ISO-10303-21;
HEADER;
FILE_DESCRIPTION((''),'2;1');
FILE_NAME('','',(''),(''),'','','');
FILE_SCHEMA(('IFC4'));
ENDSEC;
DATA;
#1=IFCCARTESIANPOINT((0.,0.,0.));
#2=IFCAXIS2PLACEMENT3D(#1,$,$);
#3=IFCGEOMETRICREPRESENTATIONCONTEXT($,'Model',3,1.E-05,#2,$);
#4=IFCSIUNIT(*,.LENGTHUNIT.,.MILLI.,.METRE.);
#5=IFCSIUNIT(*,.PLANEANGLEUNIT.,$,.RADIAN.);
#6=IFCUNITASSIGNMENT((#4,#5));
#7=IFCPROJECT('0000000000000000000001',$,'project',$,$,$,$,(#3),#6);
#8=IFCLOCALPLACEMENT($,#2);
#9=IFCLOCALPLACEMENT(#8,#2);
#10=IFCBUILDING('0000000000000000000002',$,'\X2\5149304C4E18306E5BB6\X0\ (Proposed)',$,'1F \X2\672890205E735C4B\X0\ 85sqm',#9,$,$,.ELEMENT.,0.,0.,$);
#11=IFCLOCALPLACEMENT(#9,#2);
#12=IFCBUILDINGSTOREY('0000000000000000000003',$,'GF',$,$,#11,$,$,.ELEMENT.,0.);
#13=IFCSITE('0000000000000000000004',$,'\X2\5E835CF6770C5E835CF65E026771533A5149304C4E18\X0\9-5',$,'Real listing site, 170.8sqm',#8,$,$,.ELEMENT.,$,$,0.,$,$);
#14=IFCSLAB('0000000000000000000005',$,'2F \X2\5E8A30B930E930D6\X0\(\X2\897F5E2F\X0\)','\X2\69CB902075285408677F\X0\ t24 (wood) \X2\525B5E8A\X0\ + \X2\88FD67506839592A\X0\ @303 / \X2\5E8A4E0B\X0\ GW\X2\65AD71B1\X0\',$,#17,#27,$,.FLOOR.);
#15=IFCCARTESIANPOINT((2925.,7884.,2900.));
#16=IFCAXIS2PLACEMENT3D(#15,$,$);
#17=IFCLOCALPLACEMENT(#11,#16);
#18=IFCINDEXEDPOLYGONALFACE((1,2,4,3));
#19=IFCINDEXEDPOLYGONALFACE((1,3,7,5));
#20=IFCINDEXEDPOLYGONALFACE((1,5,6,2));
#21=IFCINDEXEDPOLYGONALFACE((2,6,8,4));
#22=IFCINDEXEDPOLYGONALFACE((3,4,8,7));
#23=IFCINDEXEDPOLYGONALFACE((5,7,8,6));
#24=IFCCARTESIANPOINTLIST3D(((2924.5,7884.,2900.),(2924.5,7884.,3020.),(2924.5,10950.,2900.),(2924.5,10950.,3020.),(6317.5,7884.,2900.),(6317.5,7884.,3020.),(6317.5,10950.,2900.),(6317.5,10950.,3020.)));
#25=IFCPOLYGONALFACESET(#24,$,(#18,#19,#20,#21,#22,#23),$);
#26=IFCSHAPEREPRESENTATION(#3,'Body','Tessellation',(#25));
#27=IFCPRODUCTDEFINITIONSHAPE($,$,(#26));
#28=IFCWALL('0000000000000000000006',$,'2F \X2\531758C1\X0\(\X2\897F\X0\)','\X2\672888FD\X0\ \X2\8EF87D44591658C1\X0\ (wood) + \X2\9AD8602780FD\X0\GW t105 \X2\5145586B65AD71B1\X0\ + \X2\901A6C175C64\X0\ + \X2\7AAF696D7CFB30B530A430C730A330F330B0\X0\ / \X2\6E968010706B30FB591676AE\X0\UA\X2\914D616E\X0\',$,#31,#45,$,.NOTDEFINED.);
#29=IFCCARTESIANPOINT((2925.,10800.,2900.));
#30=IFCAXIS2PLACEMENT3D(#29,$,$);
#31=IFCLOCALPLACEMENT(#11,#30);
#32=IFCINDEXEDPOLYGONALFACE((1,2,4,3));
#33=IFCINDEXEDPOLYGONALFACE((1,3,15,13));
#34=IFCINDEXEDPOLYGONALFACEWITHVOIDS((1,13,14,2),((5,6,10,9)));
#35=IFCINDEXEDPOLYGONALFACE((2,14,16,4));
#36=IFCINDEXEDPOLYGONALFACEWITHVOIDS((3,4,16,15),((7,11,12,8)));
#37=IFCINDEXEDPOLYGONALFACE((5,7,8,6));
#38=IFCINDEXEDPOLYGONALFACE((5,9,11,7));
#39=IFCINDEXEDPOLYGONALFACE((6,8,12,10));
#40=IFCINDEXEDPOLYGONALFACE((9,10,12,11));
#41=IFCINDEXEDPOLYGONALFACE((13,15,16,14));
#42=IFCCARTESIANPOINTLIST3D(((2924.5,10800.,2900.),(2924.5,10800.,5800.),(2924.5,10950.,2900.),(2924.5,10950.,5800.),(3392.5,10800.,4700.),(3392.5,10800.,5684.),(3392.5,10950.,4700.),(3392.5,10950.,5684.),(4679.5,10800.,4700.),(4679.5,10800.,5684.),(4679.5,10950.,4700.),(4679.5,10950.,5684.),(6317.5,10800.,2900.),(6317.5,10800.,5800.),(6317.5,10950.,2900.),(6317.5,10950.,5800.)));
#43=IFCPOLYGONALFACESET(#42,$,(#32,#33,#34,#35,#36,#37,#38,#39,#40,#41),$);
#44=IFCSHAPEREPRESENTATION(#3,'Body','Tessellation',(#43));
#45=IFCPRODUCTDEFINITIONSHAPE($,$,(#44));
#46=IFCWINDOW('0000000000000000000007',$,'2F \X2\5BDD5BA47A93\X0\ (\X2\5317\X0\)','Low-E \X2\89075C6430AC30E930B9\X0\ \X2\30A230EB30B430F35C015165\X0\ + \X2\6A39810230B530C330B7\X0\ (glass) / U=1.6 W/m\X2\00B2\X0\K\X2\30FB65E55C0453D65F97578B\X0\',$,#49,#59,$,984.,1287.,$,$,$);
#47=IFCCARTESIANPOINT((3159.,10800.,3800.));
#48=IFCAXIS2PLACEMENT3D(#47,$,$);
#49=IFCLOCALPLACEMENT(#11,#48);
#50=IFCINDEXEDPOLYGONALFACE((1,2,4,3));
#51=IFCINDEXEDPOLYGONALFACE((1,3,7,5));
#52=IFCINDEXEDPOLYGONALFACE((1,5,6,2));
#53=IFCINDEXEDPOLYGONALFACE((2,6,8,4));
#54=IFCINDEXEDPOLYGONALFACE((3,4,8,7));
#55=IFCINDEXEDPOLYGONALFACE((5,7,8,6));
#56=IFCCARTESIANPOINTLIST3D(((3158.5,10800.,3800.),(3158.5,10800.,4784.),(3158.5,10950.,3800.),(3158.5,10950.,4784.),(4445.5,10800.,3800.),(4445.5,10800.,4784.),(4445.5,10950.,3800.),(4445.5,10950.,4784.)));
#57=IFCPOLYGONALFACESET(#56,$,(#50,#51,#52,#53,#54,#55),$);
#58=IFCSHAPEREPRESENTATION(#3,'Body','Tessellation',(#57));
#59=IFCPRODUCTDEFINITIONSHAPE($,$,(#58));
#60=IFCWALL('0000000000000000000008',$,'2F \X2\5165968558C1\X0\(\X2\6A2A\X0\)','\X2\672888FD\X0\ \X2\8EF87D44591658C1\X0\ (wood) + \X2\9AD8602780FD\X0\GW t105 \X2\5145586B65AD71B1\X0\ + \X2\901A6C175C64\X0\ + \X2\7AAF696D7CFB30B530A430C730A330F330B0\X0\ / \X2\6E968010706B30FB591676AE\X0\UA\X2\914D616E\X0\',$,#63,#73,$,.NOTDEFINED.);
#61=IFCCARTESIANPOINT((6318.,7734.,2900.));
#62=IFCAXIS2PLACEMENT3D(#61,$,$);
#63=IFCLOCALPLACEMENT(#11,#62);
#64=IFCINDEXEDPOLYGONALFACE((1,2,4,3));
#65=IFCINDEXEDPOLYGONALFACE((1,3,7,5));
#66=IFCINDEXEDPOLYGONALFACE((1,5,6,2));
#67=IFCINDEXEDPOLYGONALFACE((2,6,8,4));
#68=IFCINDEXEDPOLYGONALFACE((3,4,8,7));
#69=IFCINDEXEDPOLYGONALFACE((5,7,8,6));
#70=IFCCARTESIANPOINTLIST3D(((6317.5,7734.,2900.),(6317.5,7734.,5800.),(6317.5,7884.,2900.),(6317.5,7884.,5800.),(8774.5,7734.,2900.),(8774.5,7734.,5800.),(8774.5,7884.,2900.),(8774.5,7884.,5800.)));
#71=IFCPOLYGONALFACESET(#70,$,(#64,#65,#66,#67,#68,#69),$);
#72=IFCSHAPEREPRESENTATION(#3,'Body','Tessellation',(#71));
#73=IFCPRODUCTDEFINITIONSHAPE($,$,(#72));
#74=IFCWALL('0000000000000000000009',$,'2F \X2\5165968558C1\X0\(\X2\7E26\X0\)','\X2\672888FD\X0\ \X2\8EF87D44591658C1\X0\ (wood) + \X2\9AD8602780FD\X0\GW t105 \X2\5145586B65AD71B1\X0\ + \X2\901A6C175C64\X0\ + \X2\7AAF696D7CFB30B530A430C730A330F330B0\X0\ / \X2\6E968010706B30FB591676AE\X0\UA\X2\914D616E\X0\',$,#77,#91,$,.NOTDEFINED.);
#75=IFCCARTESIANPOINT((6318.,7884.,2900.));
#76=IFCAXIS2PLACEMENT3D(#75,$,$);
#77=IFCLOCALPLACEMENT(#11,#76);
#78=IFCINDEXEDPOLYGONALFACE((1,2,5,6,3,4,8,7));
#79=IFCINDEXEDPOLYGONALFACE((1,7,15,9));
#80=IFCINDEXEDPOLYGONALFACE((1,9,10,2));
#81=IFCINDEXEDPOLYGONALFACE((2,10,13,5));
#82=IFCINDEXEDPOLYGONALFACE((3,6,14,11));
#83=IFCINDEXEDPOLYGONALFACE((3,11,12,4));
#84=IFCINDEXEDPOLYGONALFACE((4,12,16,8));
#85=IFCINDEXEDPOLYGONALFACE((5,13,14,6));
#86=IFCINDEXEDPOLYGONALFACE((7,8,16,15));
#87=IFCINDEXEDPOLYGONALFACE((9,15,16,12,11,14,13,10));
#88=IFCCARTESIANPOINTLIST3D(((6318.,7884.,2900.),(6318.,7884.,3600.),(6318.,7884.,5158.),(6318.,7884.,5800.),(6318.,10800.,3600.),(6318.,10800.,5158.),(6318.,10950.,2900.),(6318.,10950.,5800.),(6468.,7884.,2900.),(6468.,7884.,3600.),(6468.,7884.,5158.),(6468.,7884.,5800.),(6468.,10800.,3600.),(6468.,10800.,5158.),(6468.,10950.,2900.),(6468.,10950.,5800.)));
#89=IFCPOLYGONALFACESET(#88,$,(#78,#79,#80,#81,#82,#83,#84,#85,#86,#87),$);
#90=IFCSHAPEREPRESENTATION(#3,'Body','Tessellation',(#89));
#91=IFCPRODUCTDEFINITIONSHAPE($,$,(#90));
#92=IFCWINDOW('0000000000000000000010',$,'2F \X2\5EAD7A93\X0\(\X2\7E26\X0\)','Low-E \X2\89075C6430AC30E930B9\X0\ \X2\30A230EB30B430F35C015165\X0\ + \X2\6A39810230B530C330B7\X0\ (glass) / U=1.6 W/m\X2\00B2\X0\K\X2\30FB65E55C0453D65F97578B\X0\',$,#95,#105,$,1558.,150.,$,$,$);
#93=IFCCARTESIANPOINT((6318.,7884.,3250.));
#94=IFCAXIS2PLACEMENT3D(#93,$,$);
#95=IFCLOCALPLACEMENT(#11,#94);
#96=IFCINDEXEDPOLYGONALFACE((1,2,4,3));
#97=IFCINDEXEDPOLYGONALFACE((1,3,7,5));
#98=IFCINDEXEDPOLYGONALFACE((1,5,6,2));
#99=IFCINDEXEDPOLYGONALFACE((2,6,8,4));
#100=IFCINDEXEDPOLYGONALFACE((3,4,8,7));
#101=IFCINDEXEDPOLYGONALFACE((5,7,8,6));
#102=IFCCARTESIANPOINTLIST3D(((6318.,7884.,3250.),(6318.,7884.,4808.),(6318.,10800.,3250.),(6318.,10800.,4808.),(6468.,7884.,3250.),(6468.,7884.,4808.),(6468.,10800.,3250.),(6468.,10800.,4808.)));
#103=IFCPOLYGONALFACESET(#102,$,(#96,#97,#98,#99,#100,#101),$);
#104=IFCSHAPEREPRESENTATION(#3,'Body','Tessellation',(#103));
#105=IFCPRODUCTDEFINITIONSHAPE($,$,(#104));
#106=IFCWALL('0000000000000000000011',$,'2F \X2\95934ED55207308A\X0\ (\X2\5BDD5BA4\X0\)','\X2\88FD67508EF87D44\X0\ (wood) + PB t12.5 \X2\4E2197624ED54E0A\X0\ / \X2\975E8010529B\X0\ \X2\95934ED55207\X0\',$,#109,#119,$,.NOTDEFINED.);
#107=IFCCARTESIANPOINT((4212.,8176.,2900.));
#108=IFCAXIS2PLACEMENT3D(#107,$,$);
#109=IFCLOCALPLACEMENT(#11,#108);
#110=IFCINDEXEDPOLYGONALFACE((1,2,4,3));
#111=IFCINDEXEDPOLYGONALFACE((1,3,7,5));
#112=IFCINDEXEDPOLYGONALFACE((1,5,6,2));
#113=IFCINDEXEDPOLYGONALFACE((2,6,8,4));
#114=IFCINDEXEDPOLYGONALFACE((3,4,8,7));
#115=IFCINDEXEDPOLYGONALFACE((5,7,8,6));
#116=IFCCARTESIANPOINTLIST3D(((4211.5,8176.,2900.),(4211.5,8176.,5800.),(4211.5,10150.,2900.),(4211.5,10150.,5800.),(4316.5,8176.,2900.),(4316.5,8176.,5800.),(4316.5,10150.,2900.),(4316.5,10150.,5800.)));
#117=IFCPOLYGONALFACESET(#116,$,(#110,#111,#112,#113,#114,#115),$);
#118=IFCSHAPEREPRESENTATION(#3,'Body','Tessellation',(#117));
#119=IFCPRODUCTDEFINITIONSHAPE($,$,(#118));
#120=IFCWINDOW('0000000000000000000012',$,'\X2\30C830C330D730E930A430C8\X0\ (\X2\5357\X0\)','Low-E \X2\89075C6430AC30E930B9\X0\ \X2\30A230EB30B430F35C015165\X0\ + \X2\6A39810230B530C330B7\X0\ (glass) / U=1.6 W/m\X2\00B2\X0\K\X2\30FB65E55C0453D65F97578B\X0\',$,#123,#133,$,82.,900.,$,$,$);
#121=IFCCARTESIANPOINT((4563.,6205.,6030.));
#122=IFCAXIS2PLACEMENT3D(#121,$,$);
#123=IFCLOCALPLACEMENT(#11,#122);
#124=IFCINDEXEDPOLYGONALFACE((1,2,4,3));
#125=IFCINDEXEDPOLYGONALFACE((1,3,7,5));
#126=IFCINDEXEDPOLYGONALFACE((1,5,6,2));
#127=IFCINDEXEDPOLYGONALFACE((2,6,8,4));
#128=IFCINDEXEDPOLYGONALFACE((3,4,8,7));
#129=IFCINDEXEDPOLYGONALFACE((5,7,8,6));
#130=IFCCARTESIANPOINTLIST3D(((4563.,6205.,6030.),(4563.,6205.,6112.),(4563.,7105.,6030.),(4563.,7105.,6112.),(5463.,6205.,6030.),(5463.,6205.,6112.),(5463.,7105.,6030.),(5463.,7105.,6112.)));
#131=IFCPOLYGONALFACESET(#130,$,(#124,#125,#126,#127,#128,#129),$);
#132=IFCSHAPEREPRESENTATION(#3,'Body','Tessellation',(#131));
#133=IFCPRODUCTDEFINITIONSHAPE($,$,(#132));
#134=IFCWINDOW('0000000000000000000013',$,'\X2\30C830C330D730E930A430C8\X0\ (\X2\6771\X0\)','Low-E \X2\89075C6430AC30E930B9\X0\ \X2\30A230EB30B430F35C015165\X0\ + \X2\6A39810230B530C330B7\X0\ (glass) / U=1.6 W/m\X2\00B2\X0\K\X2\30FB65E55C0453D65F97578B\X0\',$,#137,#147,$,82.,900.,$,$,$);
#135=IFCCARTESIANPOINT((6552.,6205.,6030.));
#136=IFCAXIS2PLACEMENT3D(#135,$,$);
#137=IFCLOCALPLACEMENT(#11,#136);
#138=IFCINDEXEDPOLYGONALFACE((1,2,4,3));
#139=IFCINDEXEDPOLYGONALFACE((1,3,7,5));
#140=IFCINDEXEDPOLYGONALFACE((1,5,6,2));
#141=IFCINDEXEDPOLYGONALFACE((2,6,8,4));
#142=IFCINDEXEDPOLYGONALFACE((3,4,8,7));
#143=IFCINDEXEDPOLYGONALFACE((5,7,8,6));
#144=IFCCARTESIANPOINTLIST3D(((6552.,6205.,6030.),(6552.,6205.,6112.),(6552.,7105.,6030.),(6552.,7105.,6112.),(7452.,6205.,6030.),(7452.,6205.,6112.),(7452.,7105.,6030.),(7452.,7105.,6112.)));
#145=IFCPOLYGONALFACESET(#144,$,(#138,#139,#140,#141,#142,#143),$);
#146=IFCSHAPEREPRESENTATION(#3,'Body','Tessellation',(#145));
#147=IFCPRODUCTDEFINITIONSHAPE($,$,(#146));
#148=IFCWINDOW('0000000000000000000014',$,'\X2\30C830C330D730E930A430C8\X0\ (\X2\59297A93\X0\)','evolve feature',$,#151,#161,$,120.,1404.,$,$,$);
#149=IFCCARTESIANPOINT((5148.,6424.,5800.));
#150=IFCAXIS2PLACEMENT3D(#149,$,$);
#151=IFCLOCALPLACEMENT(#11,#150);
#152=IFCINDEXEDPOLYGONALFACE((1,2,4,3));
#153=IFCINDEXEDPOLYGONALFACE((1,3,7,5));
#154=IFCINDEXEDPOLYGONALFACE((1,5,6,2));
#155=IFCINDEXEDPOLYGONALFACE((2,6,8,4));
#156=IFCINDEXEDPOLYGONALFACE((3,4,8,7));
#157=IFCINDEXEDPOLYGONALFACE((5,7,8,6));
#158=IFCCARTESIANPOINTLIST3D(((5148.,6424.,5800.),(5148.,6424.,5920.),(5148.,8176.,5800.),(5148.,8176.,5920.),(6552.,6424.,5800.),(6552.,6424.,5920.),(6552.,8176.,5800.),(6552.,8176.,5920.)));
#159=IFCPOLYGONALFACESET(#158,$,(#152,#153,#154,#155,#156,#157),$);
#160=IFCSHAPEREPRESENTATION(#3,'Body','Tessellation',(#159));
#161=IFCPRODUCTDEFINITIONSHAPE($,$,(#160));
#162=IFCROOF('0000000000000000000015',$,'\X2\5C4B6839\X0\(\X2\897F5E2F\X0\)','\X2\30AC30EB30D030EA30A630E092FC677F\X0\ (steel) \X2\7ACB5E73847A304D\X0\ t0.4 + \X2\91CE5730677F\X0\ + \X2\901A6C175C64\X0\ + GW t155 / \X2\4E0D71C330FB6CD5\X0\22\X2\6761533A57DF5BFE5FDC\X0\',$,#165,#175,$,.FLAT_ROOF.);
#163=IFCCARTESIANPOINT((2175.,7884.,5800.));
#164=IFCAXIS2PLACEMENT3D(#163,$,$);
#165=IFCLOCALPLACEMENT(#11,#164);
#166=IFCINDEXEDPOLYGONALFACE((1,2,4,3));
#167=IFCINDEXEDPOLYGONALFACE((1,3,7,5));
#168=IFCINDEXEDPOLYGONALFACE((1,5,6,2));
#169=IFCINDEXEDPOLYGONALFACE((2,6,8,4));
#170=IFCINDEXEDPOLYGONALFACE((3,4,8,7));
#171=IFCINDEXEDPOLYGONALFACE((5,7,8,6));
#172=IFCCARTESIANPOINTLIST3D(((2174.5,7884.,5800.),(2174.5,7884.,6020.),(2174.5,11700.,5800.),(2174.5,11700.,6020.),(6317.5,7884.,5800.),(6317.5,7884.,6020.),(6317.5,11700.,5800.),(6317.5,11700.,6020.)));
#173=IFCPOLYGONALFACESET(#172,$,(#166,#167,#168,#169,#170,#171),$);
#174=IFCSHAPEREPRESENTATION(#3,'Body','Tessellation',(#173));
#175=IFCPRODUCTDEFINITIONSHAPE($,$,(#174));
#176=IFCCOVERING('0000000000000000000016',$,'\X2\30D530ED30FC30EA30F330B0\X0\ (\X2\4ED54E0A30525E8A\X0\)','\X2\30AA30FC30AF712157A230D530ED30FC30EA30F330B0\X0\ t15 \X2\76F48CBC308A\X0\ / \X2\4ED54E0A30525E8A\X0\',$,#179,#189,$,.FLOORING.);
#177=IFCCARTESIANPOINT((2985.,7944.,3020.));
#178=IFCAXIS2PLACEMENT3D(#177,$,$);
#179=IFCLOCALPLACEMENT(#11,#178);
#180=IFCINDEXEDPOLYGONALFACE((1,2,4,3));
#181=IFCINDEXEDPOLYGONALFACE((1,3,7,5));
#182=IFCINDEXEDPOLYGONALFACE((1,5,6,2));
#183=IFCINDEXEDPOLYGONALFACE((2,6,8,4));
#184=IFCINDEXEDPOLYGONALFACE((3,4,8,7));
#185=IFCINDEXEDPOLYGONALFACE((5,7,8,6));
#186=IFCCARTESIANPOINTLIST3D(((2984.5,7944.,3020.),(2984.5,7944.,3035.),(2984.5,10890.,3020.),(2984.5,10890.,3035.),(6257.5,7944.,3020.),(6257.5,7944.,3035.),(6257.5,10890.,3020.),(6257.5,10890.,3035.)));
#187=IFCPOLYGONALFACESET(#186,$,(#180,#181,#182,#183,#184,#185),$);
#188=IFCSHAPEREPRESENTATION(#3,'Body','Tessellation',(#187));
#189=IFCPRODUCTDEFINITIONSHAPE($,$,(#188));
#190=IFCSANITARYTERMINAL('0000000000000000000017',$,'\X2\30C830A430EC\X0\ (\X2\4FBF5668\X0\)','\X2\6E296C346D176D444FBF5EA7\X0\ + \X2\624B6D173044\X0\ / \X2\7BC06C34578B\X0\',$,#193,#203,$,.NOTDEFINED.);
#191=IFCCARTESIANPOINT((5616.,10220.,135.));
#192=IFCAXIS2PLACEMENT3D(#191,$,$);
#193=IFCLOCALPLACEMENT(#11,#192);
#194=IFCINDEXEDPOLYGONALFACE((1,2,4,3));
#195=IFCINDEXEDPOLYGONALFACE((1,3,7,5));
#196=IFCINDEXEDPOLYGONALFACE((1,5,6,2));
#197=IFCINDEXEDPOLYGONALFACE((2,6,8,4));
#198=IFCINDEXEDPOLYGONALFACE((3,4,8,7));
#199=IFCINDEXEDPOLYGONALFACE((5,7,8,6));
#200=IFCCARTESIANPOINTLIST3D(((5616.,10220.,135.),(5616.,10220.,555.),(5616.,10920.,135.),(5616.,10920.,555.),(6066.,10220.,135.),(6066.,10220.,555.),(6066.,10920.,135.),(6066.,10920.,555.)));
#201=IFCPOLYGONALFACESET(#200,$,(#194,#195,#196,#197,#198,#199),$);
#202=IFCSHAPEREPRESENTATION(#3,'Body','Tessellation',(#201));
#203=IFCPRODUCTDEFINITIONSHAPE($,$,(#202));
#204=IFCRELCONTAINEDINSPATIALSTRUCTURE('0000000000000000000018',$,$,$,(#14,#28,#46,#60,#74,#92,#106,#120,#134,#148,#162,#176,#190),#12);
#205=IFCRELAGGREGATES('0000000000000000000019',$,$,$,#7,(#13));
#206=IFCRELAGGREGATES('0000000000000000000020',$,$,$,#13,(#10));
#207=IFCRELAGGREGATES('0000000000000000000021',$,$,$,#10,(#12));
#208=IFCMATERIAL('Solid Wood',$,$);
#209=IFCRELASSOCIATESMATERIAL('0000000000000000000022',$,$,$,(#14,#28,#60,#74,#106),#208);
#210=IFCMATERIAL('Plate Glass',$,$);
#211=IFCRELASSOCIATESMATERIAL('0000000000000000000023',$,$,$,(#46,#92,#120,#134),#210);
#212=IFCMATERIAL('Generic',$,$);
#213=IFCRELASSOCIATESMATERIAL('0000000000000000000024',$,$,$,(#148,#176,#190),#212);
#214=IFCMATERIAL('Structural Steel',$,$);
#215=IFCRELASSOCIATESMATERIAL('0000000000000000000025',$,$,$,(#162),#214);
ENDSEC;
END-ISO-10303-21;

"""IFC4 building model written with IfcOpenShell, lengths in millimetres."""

from ifc_helpers import new_model, si_unit, frame, frame_2d, origin, place, context, project, spatial, rectangle, extrude, material, element, fill, save


model = new_model("IFC4")

# Units and contexts
model_context = context("Model", 3, precision=1e-05, world=origin())
ifc_project = project(units=[si_unit("LENGTHUNIT", "METRE", prefix="MILLI"), si_unit("PLANEANGLEUNIT", "RADIAN")], contexts=[model_context])

# Site, building, storey
site_placement = place(None, origin())
site = spatial("IfcSite", under=ifc_project, at=site_placement, Name="広島県広島市東区光が丘9-5", ObjectType="Real listing site, 170.8sqm", CompositionType="ELEMENT", RefElevation=0.0)
building_placement = place(site_placement, origin())
building = spatial("IfcBuilding", under=site, at=building_placement, Name="光が丘の家 (Proposed)", ObjectType="1F 木造平屋 85sqm", CompositionType="ELEMENT", ElevationOfRefHeight=0.0, ElevationOfTerrain=0.0)
storey_placement = place(building_placement, origin())
storey = spatial("IfcBuildingStorey", under=building, at=storey_placement, Name="GF", CompositionType="ELEMENT", Elevation=0.0)

# Slab
ifc_material_1 = material(Name="Solid Wood")
slab_placement = place(storey_placement, frame((2925.0, 7884.0, 2900.0)))
element("IfcSlab", 1, at=slab_placement, inside=storey, material=ifc_material_1, Name="2F 床スラブ(西帯)", Description="構造用合板 t24 (wood) 剛床 + 製材根太 @303 / 床下 GW断熱", PredefinedType="FLOOR", context=model_context, shape_type="SweptSolid", body=[
    extrude(rectangle(XDim=3393.0, YDim=3066.0, at=frame_2d((1696.0, 1533.0))), frame((2925.0, 7884.0, 2900.0)), (0.0, 0.0, 1.0), 120.0),
])

# Wall, opening, window
wall_1_placement = place(storey_placement, frame((2925.0, 10800.0, 2900.0)))
wall_1 = element("IfcWall", 2, at=wall_1_placement, inside=storey, material=ifc_material_1, Name="2F 北壁(西)", Description="木製 軸組外壁 (wood) + 高性能GW t105 充填断熱 + 通気層 + 窯業系サイディング / 準耐火・外皮UA配慮", PredefinedType="NOTDEFINED", context=model_context, shape_type="SweptSolid", body=[
    extrude(rectangle(XDim=3393.0, YDim=150.0, at=frame_2d((1696.0, 75.0))), frame((2925.0, 10800.0, 2900.0)), (0.0, 0.0, 1.0), 2900.0),
])
opening_1_placement = place(storey_placement, frame((3159.0, 10800.0, 3800.0)))
opening_1 = element("IfcOpeningElement", 3, at=opening_1_placement, cuts=wall_1, PredefinedType="NOTDEFINED", context=model_context, shape_type="SweptSolid", body=[
    extrude(rectangle(XDim=1287.0, YDim=150.0, at=frame_2d((643.0, 75.0))), frame((3159.0, 10800.0, 3800.0)), (0.0, 0.0, 1.0), 984.0),
])
ifc_material_2 = material(Name="Plate Glass")
window_1_placement = place(storey_placement, frame((3159.0, 10800.0, 3800.0)))
window_1 = element("IfcWindow", 4, at=window_1_placement, inside=storey, material=ifc_material_2, Name="2F 寝室窓 (北)", Description="Low-E 複層ガラス アルゴン封入 + 樹脂サッシ (glass) / U=1.6 W/m²K・日射取得型", OverallHeight=984.0, OverallWidth=1287.0, context=model_context, shape_type="SweptSolid", body=[
    extrude(rectangle(XDim=1287.0, YDim=150.0, at=frame_2d((643.0, 75.0))), frame((3159.0, 10800.0, 3800.0)), (0.0, 0.0, 1.0), 984.0),
])
fill(opening_1, window_1)

# Wall
wall_2_placement = place(storey_placement, frame((6318.0, 7734.0, 2900.0)))
element("IfcWall", 5, at=wall_2_placement, inside=storey, material=ifc_material_1, Name="2F 入隅壁(横)", Description="木製 軸組外壁 (wood) + 高性能GW t105 充填断熱 + 通気層 + 窯業系サイディング / 準耐火・外皮UA配慮", PredefinedType="NOTDEFINED", context=model_context, shape_type="SweptSolid", body=[
    extrude(rectangle(XDim=2457.0, YDim=150.0, at=frame_2d((1228.0, 75.0))), frame((6318.0, 7734.0, 2900.0)), (0.0, 0.0, 1.0), 2900.0),
])

# Wall, opening, window
wall_3_placement = place(storey_placement, frame((6318.0, 7884.0, 2900.0)))
wall_3 = element("IfcWall", 6, at=wall_3_placement, inside=storey, material=ifc_material_1, Name="2F 入隅壁(縦)", Description="木製 軸組外壁 (wood) + 高性能GW t105 充填断熱 + 通気層 + 窯業系サイディング / 準耐火・外皮UA配慮", PredefinedType="NOTDEFINED", context=model_context, shape_type="SweptSolid", body=[
    extrude(rectangle(XDim=150.0, YDim=3066.0, at=frame_2d((75.0, 1533.0))), frame((6318.0, 7884.0, 2900.0)), (0.0, 0.0, 1.0), 2900.0),
])
opening_2_placement = place(storey_placement, frame((6318.0, 7884.0, 3250.0)))
opening_2 = element("IfcOpeningElement", 7, at=opening_2_placement, cuts=wall_3, PredefinedType="NOTDEFINED", context=model_context, shape_type="SweptSolid", body=[
    extrude(rectangle(XDim=150.0, YDim=2916.0, at=frame_2d((75.0, 1458.0))), frame((6318.0, 7884.0, 3250.0)), (0.0, 0.0, 1.0), 1558.0),
])
window_2_placement = place(storey_placement, frame((6318.0, 7884.0, 3250.0)))
window_2 = element("IfcWindow", 8, at=window_2_placement, inside=storey, material=ifc_material_2, Name="2F 庭窓(縦)", Description="Low-E 複層ガラス アルゴン封入 + 樹脂サッシ (glass) / U=1.6 W/m²K・日射取得型", OverallHeight=1558.0, OverallWidth=150.0, context=model_context, shape_type="SweptSolid", body=[
    extrude(rectangle(XDim=150.0, YDim=2916.0, at=frame_2d((75.0, 1458.0))), frame((6318.0, 7884.0, 3250.0)), (0.0, 0.0, 1.0), 1558.0),
])
fill(opening_2, window_2)

# Wall
wall_4_placement = place(storey_placement, frame((4212.0, 8176.0, 2900.0)))
element("IfcWall", 9, at=wall_4_placement, inside=storey, material=ifc_material_1, Name="2F 間仕切り (寝室)", Description="製材軸組 (wood) + PB t12.5 両面仕上 / 非耐力 間仕切", PredefinedType="NOTDEFINED", context=model_context, shape_type="SweptSolid", body=[
    extrude(rectangle(XDim=105.0, YDim=1974.0, at=frame_2d((52.0, 987.0))), frame((4212.0, 8176.0, 2900.0)), (0.0, 0.0, 1.0), 2900.0),
])

# Windows
window_3_placement = place(storey_placement, frame((4563.0, 6205.0, 6030.0)))
element("IfcWindow", 10, at=window_3_placement, inside=storey, material=ifc_material_2, Name="トップライト (南)", Description="Low-E 複層ガラス アルゴン封入 + 樹脂サッシ (glass) / U=1.6 W/m²K・日射取得型", OverallHeight=82.0, OverallWidth=900.0, context=model_context, shape_type="SweptSolid", body=[
    extrude(rectangle(XDim=900.0, YDim=900.0, at=frame_2d((450.0, 450.0))), frame((4563.0, 6205.0, 6030.0)), (0.0, 0.0, 1.0), 82.0),
])
window_4_placement = place(storey_placement, frame((6552.0, 6205.0, 6030.0)))
element("IfcWindow", 11, at=window_4_placement, inside=storey, material=ifc_material_2, Name="トップライト (東)", Description="Low-E 複層ガラス アルゴン封入 + 樹脂サッシ (glass) / U=1.6 W/m²K・日射取得型", OverallHeight=82.0, OverallWidth=900.0, context=model_context, shape_type="SweptSolid", body=[
    extrude(rectangle(XDim=900.0, YDim=900.0, at=frame_2d((450.0, 450.0))), frame((6552.0, 6205.0, 6030.0)), (0.0, 0.0, 1.0), 82.0),
])
ifc_material_3 = material(Name="Generic")
window_5_placement = place(storey_placement, frame((5148.0, 6424.0, 5800.0)))
element("IfcWindow", 12, at=window_5_placement, inside=storey, material=ifc_material_3, Name="トップライト (天窓)", Description="evolve feature", OverallHeight=120.0, OverallWidth=1404.0, context=model_context, shape_type="SweptSolid", body=[
    extrude(rectangle(XDim=1404.0, YDim=1752.0, at=frame_2d((702.0, 876.0))), frame((5148.0, 6424.0, 5800.0)), (0.0, 0.0, 1.0), 120.0),
])

# Roof
ifc_material_4 = material(Name="Structural Steel")
for number, where, name in (
    (13, (2175.0, 7884.0, 5800.0), "屋根(西帯)"),
):
    element("IfcRoof", number, at=place(storey_placement, frame(where)), inside=storey, material=ifc_material_4, Name=name, Description="ガルバリウム鋼板 (steel) 立平葺き t0.4 + 野地板 + 通気層 + GW t155 / 不燃・法22条区域対応", PredefinedType="FLAT_ROOF", context=model_context, shape_type="SweptSolid", body=[
        extrude(rectangle(XDim=4143.0, YDim=3816.0, at=frame_2d((2071.0, 1908.0))), frame((2175.0, 7884.0, 5800.0)), (0.0, 0.0, 1.0), 220.0),
    ])

# Covering
covering_placement = place(storey_placement, frame((2985.0, 7944.0, 3020.0)))
element("IfcCovering", 14, at=covering_placement, inside=storey, material=ifc_material_3, Name="フローリング (仕上げ床)", Description="オーク無垢フローリング t15 直貼り / 仕上げ床", PredefinedType="FLOORING", context=model_context, shape_type="SweptSolid", body=[
    extrude(rectangle(XDim=3273.0, YDim=2946.0, at=frame_2d((1636.0, 1473.0))), frame((2985.0, 7944.0, 3020.0)), (0.0, 0.0, 1.0), 15.0),
])

# Sanitary terminal
sanitary_terminal_placement = place(storey_placement, frame((5616.0, 10220.0, 135.0)))
element("IfcSanitaryTerminal", 15, at=sanitary_terminal_placement, inside=storey, material=ifc_material_3, Name="トイレ (便器)", Description="温水洗浄便座 + 手洗い / 節水型", PredefinedType="NOTDEFINED", context=model_context, shape_type="SweptSolid", body=[
    extrude(rectangle(XDim=450.0, YDim=700.0, at=frame_2d((225.0, 350.0))), frame((5616.0, 10220.0, 135.0)), (0.0, 0.0, 1.0), 420.0),
])

save(model, "model.ifc")
